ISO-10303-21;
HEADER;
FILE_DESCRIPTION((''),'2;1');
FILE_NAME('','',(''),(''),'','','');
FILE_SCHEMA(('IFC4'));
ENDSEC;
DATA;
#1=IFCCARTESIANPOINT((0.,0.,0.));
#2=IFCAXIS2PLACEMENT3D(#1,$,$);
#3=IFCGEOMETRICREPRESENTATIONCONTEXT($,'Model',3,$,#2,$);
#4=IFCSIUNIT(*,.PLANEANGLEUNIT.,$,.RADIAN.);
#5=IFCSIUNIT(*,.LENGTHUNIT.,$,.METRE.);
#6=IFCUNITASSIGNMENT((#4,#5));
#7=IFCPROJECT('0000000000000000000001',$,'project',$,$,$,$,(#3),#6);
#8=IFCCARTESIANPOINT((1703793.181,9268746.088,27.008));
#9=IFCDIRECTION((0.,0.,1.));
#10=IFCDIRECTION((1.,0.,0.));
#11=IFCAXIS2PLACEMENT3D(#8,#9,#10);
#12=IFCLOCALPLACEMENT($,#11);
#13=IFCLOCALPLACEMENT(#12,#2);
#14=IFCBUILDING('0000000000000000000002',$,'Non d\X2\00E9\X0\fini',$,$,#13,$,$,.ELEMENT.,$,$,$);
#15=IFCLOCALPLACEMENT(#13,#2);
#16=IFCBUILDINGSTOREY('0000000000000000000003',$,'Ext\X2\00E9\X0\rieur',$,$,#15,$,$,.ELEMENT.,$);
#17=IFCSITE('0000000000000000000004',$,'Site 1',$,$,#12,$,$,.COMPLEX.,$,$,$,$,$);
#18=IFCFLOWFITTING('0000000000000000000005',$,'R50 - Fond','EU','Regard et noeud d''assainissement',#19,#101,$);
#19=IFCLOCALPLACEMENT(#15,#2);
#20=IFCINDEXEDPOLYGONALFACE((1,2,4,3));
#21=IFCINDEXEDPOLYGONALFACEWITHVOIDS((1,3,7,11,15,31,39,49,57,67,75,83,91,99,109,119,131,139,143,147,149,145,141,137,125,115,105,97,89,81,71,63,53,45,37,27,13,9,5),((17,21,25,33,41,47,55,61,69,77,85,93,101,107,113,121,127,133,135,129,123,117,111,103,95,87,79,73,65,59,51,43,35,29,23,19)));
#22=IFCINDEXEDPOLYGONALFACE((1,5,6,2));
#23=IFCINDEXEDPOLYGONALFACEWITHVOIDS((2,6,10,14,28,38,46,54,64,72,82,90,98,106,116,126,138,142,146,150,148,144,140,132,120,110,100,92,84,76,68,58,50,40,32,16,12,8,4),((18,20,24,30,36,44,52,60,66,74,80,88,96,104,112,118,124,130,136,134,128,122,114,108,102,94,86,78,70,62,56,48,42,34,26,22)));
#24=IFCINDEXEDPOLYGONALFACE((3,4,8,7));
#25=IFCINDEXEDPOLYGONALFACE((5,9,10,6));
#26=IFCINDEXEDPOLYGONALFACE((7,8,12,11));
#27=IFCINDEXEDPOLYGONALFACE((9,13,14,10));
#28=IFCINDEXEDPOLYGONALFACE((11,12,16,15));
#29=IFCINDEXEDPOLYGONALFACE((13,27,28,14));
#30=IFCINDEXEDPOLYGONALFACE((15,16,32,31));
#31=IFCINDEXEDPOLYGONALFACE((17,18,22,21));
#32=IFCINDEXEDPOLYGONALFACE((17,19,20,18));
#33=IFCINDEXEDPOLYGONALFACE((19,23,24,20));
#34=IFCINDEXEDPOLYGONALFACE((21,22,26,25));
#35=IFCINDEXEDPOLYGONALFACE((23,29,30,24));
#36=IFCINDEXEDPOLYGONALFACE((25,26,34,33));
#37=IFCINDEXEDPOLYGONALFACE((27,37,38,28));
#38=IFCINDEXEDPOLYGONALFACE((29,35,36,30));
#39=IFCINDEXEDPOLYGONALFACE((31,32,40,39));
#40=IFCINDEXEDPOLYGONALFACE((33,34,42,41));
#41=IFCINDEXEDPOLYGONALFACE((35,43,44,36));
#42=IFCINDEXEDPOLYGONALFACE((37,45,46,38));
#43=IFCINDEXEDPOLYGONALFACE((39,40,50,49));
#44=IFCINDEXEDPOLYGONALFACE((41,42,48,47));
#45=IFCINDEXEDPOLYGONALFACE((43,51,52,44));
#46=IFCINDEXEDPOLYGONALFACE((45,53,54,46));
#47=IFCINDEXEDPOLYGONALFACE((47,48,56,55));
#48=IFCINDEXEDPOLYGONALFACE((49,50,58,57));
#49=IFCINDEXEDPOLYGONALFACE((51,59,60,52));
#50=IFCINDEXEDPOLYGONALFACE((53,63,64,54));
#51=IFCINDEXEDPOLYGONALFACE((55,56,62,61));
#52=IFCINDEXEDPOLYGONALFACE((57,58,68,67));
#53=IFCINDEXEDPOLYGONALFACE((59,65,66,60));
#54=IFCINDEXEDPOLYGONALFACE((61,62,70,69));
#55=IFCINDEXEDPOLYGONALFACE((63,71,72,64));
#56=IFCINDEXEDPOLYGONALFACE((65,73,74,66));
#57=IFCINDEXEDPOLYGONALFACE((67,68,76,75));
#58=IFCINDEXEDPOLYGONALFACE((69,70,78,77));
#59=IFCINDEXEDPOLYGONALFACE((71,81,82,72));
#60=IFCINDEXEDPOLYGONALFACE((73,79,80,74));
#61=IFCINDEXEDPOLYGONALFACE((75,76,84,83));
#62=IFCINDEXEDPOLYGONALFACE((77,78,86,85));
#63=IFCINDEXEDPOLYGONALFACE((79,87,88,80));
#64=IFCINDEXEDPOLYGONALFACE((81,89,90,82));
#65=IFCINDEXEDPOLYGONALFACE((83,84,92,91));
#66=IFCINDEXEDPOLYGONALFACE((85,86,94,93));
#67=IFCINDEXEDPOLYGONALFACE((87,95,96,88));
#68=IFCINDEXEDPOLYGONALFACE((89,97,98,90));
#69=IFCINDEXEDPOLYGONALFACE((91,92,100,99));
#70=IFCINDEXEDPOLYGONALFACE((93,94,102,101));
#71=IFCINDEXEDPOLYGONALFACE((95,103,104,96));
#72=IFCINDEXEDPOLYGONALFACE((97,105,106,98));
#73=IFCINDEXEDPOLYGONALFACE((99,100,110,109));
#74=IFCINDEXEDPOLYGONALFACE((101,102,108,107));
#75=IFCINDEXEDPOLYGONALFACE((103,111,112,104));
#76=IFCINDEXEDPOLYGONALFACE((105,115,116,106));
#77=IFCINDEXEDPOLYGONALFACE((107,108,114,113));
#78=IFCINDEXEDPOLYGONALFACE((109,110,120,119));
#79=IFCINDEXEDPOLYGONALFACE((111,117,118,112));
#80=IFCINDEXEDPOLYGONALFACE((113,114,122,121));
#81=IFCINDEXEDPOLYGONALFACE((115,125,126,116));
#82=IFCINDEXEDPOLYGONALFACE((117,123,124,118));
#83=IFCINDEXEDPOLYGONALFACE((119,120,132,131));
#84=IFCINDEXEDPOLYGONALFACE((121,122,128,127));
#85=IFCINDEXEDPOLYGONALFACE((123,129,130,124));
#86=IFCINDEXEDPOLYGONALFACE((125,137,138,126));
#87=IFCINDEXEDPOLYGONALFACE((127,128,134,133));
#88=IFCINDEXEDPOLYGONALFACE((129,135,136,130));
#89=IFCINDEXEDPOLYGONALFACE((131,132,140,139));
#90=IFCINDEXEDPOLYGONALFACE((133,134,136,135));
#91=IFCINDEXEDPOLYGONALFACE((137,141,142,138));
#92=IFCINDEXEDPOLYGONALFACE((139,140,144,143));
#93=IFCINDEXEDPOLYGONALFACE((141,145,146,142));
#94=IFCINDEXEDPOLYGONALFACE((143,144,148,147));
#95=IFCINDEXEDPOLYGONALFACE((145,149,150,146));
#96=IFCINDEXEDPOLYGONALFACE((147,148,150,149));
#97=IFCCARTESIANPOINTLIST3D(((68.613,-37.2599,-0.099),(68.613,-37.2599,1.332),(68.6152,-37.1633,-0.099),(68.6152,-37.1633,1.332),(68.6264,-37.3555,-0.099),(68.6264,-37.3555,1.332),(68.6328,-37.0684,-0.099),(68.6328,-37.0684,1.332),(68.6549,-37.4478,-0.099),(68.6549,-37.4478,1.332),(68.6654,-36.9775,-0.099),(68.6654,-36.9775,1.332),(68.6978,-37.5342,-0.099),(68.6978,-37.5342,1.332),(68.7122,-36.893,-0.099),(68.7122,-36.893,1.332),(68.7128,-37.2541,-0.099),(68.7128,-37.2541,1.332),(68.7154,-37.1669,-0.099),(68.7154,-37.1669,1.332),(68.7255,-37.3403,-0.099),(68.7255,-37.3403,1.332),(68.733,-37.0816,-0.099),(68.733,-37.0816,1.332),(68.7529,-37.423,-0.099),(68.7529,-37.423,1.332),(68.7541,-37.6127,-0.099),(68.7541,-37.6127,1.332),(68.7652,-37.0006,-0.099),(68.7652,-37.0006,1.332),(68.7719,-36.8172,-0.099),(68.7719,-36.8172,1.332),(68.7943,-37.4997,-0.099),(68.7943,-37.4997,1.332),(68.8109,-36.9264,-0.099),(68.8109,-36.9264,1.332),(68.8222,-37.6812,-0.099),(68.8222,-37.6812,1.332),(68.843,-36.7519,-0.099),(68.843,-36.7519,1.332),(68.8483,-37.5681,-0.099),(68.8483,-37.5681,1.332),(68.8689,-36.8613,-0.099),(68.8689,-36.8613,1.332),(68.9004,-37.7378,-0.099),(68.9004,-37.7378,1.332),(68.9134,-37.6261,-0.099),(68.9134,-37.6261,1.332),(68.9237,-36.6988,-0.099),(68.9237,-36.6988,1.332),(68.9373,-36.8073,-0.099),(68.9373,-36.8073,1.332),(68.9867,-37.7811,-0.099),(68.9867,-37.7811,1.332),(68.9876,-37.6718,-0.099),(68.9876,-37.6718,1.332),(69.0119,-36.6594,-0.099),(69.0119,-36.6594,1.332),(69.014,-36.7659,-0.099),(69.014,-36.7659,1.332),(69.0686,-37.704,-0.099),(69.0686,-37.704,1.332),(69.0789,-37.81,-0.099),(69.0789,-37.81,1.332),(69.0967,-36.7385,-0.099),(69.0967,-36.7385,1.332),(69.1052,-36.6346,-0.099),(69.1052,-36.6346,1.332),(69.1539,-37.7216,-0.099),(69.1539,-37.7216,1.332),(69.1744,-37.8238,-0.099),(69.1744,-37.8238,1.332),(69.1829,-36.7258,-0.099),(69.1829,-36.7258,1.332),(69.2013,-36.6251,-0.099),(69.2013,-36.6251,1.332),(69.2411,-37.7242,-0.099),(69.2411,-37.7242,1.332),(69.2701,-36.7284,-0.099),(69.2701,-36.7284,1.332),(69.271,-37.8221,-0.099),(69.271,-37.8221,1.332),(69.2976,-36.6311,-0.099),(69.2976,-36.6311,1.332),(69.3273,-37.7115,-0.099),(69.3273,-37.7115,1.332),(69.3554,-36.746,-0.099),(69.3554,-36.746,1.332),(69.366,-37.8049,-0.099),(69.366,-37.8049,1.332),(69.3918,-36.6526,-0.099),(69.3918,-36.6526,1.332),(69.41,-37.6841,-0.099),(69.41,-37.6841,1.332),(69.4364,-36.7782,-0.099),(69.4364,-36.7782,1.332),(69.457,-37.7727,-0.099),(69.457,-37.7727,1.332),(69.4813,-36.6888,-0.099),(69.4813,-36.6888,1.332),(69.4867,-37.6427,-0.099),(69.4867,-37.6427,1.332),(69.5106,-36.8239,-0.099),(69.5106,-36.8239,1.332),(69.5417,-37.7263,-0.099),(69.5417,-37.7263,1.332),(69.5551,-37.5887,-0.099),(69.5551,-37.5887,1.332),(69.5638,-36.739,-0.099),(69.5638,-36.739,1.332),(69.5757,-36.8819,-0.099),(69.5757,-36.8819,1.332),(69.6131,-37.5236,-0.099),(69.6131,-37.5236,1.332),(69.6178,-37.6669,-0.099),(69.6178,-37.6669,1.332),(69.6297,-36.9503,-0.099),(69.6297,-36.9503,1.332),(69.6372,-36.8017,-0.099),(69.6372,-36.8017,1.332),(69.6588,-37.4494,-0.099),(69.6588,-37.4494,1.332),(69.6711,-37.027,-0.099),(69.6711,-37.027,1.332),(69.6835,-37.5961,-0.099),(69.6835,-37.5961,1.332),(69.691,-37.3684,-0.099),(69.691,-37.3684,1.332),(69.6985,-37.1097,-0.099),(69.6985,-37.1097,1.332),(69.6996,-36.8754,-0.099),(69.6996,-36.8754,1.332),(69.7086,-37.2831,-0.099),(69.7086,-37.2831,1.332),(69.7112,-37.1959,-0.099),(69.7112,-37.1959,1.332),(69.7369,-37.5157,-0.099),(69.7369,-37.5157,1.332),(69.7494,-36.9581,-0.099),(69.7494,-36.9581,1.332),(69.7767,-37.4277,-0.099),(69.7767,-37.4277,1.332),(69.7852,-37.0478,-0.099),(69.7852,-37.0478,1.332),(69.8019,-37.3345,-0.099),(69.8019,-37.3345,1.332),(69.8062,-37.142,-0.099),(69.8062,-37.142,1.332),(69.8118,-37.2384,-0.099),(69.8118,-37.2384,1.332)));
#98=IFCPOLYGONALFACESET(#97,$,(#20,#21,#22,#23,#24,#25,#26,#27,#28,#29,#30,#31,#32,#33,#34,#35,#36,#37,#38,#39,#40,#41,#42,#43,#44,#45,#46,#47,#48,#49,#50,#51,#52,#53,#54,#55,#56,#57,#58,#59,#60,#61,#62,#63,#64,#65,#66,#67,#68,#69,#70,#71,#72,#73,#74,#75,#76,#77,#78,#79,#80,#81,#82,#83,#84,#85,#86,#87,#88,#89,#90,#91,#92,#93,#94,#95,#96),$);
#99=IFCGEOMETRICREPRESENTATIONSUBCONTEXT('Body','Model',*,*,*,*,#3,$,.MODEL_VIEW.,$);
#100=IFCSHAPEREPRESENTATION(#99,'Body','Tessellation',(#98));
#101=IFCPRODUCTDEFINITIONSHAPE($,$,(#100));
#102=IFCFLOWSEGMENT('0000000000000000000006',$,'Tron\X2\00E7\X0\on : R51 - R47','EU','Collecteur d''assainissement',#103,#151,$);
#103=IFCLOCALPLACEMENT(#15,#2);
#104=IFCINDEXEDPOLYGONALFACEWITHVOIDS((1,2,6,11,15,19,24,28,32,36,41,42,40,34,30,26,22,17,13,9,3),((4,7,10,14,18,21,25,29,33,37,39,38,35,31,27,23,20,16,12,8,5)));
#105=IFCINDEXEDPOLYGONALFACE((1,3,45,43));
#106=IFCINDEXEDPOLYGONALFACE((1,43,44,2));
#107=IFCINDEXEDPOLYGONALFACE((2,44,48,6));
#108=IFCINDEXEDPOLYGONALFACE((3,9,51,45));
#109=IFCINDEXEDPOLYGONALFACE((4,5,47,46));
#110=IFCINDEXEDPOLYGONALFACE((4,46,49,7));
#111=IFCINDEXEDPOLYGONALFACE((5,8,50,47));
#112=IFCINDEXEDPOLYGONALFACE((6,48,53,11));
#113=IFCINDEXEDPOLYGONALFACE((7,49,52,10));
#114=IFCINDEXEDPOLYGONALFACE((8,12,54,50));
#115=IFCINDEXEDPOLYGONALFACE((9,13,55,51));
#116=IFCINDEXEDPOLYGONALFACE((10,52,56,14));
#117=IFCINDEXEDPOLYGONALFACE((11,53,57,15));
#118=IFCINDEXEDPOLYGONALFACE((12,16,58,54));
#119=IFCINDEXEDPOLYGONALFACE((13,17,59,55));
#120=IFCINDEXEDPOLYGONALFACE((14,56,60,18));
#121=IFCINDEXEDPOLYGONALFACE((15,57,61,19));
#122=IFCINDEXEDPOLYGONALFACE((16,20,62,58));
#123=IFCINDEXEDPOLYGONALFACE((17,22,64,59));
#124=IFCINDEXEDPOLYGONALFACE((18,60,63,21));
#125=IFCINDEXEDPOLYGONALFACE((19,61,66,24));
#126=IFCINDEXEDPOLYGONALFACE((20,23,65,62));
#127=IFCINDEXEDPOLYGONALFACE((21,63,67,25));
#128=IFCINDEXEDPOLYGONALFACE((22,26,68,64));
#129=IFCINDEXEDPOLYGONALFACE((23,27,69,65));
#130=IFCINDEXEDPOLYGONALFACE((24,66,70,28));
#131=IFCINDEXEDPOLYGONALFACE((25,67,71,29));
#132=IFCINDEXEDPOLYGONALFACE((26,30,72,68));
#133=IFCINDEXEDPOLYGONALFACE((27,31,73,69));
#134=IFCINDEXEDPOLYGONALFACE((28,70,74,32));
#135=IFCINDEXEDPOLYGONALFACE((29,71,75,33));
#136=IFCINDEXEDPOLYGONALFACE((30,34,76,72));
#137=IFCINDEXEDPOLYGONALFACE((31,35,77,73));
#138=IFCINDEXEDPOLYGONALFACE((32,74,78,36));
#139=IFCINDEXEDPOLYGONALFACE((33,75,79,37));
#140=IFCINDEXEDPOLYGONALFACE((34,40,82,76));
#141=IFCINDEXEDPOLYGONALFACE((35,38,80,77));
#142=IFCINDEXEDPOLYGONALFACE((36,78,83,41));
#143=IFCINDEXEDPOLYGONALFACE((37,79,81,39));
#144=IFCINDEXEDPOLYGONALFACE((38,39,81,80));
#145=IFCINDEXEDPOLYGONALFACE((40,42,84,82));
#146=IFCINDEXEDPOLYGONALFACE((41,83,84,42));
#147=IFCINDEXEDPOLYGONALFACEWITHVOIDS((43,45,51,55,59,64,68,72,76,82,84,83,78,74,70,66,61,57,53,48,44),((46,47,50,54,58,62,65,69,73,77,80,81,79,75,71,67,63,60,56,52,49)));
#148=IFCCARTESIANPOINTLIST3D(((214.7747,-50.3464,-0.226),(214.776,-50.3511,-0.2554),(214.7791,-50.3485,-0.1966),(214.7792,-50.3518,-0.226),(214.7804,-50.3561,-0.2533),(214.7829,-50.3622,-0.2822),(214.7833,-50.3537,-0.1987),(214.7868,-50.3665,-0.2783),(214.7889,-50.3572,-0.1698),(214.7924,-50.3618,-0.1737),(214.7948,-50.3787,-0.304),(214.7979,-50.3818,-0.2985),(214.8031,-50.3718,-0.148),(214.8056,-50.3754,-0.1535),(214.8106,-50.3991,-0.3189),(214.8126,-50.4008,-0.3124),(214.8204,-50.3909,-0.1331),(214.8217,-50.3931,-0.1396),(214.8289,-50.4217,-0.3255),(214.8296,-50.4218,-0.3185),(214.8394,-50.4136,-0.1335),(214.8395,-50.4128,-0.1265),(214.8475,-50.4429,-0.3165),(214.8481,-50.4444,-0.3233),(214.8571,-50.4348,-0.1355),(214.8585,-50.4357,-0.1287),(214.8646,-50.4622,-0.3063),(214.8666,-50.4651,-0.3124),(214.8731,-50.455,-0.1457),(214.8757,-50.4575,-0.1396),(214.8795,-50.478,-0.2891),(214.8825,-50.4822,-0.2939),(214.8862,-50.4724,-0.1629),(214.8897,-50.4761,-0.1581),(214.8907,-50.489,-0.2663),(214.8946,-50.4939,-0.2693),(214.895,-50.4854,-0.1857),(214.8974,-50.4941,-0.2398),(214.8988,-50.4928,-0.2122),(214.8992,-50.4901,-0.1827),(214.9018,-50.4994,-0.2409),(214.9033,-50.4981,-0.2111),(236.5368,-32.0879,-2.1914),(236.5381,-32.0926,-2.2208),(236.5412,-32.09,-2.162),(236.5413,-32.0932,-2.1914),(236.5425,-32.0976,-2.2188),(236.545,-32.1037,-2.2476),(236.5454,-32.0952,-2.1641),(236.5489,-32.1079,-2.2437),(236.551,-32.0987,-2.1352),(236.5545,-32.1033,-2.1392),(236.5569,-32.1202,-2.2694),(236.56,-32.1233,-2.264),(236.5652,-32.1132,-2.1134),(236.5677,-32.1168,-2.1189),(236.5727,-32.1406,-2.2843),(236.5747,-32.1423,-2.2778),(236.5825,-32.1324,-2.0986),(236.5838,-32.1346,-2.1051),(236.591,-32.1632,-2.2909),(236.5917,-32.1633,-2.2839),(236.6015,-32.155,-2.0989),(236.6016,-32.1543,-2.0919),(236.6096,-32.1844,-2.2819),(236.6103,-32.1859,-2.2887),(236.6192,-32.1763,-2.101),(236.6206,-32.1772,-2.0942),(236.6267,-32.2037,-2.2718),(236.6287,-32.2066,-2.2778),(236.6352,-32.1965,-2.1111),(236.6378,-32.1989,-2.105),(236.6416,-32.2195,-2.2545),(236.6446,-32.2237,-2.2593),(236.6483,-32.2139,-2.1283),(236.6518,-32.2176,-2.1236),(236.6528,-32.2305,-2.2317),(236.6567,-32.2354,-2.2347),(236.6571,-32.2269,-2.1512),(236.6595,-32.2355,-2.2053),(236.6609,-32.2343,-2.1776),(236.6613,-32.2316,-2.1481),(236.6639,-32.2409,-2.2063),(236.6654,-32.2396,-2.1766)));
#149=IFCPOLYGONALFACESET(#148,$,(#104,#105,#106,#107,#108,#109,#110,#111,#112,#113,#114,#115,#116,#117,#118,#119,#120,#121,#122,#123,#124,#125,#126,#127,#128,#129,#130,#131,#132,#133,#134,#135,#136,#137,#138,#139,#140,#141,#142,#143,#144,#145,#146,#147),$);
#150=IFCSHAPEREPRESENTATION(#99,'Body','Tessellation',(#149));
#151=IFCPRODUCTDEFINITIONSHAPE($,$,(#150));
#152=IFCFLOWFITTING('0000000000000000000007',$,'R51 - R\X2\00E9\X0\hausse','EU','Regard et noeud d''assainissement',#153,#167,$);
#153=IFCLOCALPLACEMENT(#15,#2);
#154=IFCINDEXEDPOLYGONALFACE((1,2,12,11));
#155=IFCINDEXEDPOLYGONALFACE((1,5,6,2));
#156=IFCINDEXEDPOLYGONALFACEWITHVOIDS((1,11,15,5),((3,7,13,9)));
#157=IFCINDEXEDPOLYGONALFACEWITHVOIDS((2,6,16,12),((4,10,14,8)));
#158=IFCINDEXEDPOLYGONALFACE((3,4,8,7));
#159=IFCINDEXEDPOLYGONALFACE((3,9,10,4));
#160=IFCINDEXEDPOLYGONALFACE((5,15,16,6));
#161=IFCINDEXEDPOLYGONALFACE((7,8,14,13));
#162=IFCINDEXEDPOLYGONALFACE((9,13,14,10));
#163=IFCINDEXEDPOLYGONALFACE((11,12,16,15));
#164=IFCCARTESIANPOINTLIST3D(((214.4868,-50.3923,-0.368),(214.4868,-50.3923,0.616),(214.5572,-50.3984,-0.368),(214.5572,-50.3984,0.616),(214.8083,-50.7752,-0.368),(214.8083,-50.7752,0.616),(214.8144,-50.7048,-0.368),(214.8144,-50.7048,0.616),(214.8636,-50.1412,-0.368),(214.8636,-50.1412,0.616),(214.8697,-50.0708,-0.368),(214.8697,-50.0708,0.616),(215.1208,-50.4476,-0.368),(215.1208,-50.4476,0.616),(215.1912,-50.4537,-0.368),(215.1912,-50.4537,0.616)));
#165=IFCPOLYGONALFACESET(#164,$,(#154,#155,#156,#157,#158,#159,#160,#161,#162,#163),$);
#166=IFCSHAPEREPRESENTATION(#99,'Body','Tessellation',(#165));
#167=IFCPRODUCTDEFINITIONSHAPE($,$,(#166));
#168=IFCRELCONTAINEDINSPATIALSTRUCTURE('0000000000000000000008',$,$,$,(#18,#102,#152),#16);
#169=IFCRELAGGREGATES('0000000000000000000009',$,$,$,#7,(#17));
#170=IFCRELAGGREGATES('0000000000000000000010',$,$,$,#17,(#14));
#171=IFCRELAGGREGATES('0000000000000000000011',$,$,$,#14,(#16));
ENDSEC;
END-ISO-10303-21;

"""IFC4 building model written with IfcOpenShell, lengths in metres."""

from ifc_helpers import new_model, si_unit, frame, origin, origin_2d, place, context, subcontext, project, spatial, hollow_rectangle, hollow_circle, extrude, element, save


model = new_model("IFC4")

# Units and contexts
model_context = context("Model", 3, world=origin())
body_context = subcontext(model_context, "Body", "Model", "MODEL_VIEW")
ifc_project = project(units=[si_unit("PLANEANGLEUNIT", "RADIAN"), si_unit("LENGTHUNIT", "METRE")], contexts=[model_context])

# Site, building, storey
site_placement = place(None, frame((1703793.181, 9268746.088, 27.008), z_axis=(0.0, 0.0, 1.0), x_axis=(1.0, 0.0, 0.0)))
site = spatial("IfcSite", under=ifc_project, at=site_placement, Name="Site 1", CompositionType="COMPLEX")
building_placement = place(site_placement, origin())
building = spatial("IfcBuilding", under=site, at=building_placement, Name="Non défini", CompositionType="ELEMENT")
storey_placement = place(building_placement, origin())
storey = spatial("IfcBuildingStorey", under=building, at=storey_placement, Name="Extérieur", CompositionType="ELEMENT")

# Flow fitting
flow_fitting_1_placement = place(storey_placement, origin())
element("IfcFlowFitting", 1, at=flow_fitting_1_placement, inside=storey, Name="R50 - Fond", Description="EU", ObjectType="Regard et noeud d'assainissement", context=body_context, shape_type="SweptSolid", body=[
    extrude(hollow_circle(Radius=0.6, WallThickness=0.1, at=origin_2d()), frame((69.212, -37.225, -0.099), z_axis=(0.0, 0.0, 1.0), x_axis=(0.449, 0.894, 0.0)), (0.0, 0.0, 1.0), 1.431),
])

# Flow segment
flow_segment_1_placement = place(storey_placement, origin())
element("IfcFlowSegment", 2, at=flow_segment_1_placement, inside=storey, Name="Tronçon : R51 - R47", Description="EU", ObjectType="Collecteur d'assainissement", context=body_context, shape_type="SweptSolid", body=[
    extrude(hollow_circle(Radius=0.1, WallThickness=0.007, at=origin_2d()), frame((214.839, -50.423, -0.226), z_axis=(0.764, 0.641, -0.069), x_axis=(-0.643, 0.766, 0.0)), (0.0, 0.0, 1.0), 28.475),
])

# Flow fitting
flow_fitting_2_placement = place(storey_placement, origin())
element("IfcFlowFitting", 3, at=flow_fitting_2_placement, inside=storey, Name="R51 - Réhausse", Description="EU", ObjectType="Regard et noeud d'assainissement", context=body_context, shape_type="SweptSolid", body=[
    extrude(hollow_rectangle(XDim=0.5, YDim=0.5, WallThickness=0.05, at=origin_2d()), frame((214.839, -50.423, -0.368), z_axis=(0.0, 0.0, 1.0), x_axis=(0.766, 0.643, 0.0)), (0.0, 0.0, 1.0), 0.984),
])

save(model, "model.ifc")
